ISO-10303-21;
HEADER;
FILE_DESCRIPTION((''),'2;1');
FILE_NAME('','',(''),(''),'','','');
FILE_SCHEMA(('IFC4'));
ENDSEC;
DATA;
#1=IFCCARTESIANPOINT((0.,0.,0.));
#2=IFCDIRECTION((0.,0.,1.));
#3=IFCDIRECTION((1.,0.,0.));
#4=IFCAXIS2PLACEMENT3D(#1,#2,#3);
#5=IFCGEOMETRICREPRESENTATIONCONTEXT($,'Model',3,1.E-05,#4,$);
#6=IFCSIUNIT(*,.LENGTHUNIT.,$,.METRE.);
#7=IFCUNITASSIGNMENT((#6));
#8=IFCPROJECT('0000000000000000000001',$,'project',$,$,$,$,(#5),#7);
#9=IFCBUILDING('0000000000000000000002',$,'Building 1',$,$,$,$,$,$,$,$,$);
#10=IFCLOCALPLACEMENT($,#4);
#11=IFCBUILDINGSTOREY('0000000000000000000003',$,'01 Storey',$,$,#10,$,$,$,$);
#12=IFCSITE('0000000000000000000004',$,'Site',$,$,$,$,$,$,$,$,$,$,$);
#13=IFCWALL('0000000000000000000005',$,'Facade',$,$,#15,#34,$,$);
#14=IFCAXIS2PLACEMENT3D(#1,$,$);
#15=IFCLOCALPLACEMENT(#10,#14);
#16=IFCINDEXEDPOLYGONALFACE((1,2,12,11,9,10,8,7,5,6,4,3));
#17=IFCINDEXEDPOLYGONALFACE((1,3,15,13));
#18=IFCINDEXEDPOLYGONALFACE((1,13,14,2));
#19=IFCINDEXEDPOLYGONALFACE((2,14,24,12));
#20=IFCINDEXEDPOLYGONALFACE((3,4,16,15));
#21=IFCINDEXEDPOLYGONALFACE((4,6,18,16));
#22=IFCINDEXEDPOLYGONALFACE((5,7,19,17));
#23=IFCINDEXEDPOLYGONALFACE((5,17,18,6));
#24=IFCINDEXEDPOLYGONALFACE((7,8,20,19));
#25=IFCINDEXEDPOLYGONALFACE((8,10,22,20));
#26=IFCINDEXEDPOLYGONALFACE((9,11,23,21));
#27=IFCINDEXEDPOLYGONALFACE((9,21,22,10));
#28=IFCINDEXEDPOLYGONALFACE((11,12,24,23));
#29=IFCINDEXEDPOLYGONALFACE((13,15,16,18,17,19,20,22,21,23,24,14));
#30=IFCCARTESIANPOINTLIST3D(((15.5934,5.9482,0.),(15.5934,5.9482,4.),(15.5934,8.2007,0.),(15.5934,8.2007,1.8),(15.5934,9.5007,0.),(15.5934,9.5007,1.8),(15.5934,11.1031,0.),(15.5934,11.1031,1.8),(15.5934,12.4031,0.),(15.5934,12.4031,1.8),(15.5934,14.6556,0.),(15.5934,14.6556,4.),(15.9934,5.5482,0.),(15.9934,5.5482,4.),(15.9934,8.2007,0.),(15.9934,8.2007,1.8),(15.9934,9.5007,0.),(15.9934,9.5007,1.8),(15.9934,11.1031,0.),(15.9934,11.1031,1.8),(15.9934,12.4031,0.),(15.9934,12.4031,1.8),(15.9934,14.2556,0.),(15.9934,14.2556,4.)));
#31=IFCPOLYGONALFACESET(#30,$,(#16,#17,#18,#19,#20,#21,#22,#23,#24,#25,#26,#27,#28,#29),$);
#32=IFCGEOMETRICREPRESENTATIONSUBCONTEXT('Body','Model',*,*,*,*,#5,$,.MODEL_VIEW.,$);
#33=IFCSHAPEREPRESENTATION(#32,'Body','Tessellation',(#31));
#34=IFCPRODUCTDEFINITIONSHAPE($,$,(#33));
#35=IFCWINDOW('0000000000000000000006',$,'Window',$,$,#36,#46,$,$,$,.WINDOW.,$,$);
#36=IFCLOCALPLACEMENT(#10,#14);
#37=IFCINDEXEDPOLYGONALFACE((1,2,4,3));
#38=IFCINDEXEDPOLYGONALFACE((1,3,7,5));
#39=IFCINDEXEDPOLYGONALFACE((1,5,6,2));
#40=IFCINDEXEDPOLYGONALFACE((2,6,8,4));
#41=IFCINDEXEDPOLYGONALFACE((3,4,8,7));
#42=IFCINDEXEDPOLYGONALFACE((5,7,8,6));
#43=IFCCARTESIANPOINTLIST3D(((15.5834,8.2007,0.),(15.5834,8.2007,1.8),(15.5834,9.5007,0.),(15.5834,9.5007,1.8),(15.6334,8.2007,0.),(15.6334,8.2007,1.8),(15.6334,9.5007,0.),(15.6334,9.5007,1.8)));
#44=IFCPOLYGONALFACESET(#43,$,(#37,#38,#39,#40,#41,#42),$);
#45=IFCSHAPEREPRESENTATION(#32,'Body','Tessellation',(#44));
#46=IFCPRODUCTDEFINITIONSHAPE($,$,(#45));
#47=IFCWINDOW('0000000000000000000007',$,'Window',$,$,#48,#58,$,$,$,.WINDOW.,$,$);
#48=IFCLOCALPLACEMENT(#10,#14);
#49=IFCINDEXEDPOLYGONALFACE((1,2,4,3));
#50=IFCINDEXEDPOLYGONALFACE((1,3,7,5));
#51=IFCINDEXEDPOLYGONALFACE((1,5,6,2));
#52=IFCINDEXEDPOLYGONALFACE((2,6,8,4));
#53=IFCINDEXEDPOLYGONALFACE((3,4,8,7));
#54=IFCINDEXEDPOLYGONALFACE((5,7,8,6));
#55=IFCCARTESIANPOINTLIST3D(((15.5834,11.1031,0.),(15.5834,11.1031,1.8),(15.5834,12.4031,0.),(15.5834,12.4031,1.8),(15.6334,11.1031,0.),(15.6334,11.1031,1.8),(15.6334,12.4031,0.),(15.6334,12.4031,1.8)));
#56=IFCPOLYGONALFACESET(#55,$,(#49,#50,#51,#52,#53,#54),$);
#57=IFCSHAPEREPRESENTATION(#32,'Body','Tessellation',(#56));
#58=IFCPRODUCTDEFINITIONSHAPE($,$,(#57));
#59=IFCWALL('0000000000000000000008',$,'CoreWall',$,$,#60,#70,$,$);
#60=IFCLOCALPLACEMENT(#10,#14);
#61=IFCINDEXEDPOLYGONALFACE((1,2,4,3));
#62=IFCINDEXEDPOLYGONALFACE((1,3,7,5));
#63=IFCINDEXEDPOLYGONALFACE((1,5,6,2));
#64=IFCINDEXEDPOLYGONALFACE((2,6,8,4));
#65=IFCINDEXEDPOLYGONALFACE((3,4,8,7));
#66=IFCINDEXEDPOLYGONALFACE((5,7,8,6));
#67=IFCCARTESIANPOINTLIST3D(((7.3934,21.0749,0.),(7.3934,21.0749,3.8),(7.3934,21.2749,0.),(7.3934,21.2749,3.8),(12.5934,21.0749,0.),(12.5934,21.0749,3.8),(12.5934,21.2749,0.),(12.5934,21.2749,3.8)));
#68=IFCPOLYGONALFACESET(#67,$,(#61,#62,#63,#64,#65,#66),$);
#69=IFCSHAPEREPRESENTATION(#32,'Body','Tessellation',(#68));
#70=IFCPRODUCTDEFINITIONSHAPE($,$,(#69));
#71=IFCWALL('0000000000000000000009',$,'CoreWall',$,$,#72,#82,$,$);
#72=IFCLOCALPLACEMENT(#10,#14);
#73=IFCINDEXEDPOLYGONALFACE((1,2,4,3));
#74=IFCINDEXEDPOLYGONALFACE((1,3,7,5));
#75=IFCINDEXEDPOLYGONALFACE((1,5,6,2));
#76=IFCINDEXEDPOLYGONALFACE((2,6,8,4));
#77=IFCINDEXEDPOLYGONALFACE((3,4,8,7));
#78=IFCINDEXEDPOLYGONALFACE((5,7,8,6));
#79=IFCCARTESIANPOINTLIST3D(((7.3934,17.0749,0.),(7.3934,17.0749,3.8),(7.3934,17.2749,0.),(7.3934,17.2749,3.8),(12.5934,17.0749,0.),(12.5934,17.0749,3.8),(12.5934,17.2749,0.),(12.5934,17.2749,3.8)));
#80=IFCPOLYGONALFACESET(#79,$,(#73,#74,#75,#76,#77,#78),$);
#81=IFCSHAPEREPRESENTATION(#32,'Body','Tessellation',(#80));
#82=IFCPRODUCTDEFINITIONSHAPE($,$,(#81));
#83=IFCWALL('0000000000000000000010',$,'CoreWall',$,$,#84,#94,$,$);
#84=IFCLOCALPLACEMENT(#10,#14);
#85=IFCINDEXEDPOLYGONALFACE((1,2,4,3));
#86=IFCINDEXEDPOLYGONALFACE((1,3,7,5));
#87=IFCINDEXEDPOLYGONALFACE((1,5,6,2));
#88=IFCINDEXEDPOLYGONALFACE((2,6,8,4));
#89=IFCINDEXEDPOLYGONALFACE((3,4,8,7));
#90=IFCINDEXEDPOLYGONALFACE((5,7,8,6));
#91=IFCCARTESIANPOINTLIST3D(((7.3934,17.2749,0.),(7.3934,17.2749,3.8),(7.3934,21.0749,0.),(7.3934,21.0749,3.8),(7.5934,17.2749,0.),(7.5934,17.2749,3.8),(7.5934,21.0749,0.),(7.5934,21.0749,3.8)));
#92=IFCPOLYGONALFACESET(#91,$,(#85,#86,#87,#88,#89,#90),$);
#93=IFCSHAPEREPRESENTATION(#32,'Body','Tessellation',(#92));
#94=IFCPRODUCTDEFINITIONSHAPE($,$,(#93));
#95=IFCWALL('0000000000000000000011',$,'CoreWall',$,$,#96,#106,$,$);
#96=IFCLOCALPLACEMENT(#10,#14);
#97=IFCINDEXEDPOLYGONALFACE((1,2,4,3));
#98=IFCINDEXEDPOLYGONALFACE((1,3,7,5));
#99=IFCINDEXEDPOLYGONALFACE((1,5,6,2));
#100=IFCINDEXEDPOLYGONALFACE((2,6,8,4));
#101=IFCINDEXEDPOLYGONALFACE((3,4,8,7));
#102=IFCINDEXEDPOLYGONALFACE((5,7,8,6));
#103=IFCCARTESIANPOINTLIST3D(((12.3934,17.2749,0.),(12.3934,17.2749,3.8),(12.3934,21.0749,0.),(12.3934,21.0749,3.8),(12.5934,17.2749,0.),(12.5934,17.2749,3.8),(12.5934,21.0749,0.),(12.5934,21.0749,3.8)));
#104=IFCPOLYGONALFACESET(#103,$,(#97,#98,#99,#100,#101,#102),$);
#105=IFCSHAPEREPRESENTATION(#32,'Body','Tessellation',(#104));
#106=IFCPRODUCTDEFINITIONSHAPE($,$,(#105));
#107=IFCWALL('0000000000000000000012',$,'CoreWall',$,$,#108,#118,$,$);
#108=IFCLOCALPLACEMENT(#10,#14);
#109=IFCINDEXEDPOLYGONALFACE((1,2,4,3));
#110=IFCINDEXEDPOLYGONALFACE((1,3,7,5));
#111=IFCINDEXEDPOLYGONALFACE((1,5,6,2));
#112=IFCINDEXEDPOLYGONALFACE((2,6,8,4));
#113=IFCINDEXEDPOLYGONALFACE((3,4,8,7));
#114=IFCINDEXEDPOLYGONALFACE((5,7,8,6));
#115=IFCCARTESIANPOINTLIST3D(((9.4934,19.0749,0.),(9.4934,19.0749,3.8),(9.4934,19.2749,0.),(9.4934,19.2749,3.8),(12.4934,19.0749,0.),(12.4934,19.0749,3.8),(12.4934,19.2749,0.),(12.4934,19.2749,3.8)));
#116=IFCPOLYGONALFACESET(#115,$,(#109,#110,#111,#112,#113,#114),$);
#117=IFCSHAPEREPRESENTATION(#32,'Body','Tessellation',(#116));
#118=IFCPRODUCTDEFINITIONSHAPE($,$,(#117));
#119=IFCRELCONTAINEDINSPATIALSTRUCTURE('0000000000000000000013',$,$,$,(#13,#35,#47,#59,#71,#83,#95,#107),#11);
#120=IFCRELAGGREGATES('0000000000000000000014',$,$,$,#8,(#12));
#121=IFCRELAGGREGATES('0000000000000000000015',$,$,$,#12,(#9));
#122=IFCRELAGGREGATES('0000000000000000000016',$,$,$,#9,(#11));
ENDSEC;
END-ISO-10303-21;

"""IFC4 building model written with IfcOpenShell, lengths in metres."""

from ifc_helpers import new_model, si_unit, origin_with_axes, place, context, subcontext, project, spatial, line, indexed_curve, outline, extrude, element, fill, save


model = new_model("IFC4")

# Units and contexts
model_context = context("Model", 3, precision=1e-05, world=origin_with_axes())
body_context = subcontext(model_context, "Body", "Model", "MODEL_VIEW")
ifc_project = project(units=[si_unit("LENGTHUNIT", "METRE")], contexts=[model_context])

# Site, building, storey
site = spatial("IfcSite", under=ifc_project, Name="Site")
building = spatial("IfcBuilding", under=site, Name="Building 1")
storey_placement = place(None, origin_with_axes())
storey = spatial("IfcBuildingStorey", under=building, at=storey_placement, Name="01 Storey")

# Wall, openings, windows
wall_1_placement = place(storey_placement, origin_with_axes())
wall_1 = element("IfcWall", 1, at=wall_1_placement, inside=storey, Name="Facade", context=body_context, shape_type="SweptSolid", body=[
    extrude(outline(indexed_curve([(15.5934, 5.9482), (15.5934, 14.6556), (15.9934, 14.2556), (15.9934, 5.5482)], segments=[line(1, 2), line(2, 3), line(3, 4)])), origin_with_axes(), (0.0, 0.0, 1.0), 4.0),
])
opening_1_placement = place(wall_1_placement, origin_with_axes())
opening_1 = element("IfcOpeningElement", 2, at=opening_1_placement, cuts=wall_1, context=body_context, shape_type="SweptSolid", body=[
    extrude(outline(indexed_curve([(16.0334, 8.2007), (15.5334, 8.2007), (15.5334, 9.5007), (16.0334, 9.5007)], segments=[line(1, 2), line(2, 3), line(3, 4)])), origin_with_axes(), (0.0, 0.0, 1.0), 1.8),
])
opening_2_placement = place(wall_1_placement, origin_with_axes())
opening_2 = element("IfcOpeningElement", 3, at=opening_2_placement, cuts=wall_1, context=body_context, shape_type="SweptSolid", body=[
    extrude(outline(indexed_curve([(16.0334, 11.1031), (15.5334, 11.1031), (15.5334, 12.4031), (16.0334, 12.4031)], segments=[line(1, 2), line(2, 3), line(3, 4)])), origin_with_axes(), (0.0, 0.0, 1.0), 1.8),
])
window_1_placement = place(storey_placement, origin_with_axes())
window_1 = element("IfcWindow", 4, at=window_1_placement, inside=storey, Name="Window", PredefinedType="WINDOW", context=body_context, shape_type="SweptSolid", body=[
    extrude(outline(indexed_curve([(15.6334, 8.2007), (15.5834, 8.2007), (15.5834, 9.5007), (15.6334, 9.5007)], segments=[line(1, 2), line(2, 3), line(3, 4)])), origin_with_axes(), (0.0, 0.0, 1.0), 1.8),
])
fill(opening_1, window_1)
window_2_placement = place(storey_placement, origin_with_axes())
window_2 = element("IfcWindow", 5, at=window_2_placement, inside=storey, Name="Window", PredefinedType="WINDOW", context=body_context, shape_type="SweptSolid", body=[
    extrude(outline(indexed_curve([(15.6334, 11.1031), (15.5834, 11.1031), (15.5834, 12.4031), (15.6334, 12.4031)], segments=[line(1, 2), line(2, 3), line(3, 4)])), origin_with_axes(), (0.0, 0.0, 1.0), 1.8),
])
fill(opening_2, window_2)

# Walls
wall_2_placement = place(storey_placement, origin_with_axes())
element("IfcWall", 6, at=wall_2_placement, inside=storey, Name="CoreWall", context=body_context, shape_type="SweptSolid", body=[
    extrude(outline(indexed_curve([(12.5934, 21.2749), (7.3934, 21.2749), (7.3934, 21.0749), (12.5934, 21.0749)], segments=[line(1, 2), line(2, 3), line(3, 4)])), origin_with_axes(), (0.0, 0.0, 1.0), 3.8),
])
wall_3_placement = place(storey_placement, origin_with_axes())
element("IfcWall", 7, at=wall_3_placement, inside=storey, Name="CoreWall", context=body_context, shape_type="SweptSolid", body=[
    extrude(outline(indexed_curve([(7.3934, 17.0749), (12.5934, 17.0749), (12.5934, 17.2749), (7.3934, 17.2749)], segments=[line(1, 2), line(2, 3), line(3, 4)])), origin_with_axes(), (0.0, 0.0, 1.0), 3.8),
])
wall_4_placement = place(storey_placement, origin_with_axes())
element("IfcWall", 8, at=wall_4_placement, inside=storey, Name="CoreWall", context=body_context, shape_type="SweptSolid", body=[
    extrude(outline(indexed_curve([(7.5934, 17.2749), (7.5934, 21.0749), (7.3934, 21.0749), (7.3934, 17.2749)], segments=[line(1, 2), line(2, 3), line(3, 4)])), origin_with_axes(), (0.0, 0.0, 1.0), 3.8),
])
wall_5_placement = place(storey_placement, origin_with_axes())
element("IfcWall", 9, at=wall_5_placement, inside=storey, Name="CoreWall", context=body_context, shape_type="SweptSolid", body=[
    extrude(outline(indexed_curve([(12.3934, 21.0749), (12.3934, 17.2749), (12.5934, 17.2749), (12.5934, 21.0749)], segments=[line(1, 2), line(2, 3), line(3, 4)])), origin_with_axes(), (0.0, 0.0, 1.0), 3.8),
])
wall_6_placement = place(storey_placement, origin_with_axes())
element("IfcWall", 10, at=wall_6_placement, inside=storey, Name="CoreWall", context=body_context, shape_type="SweptSolid", body=[
    extrude(outline(indexed_curve([(12.4934, 19.2749), (9.4934, 19.2749), (9.4934, 19.0749), (12.4934, 19.0749)], segments=[line(1, 2), line(2, 3), line(3, 4)])), origin_with_axes(), (0.0, 0.0, 1.0), 3.8),
])

save(model, "model.ifc")
